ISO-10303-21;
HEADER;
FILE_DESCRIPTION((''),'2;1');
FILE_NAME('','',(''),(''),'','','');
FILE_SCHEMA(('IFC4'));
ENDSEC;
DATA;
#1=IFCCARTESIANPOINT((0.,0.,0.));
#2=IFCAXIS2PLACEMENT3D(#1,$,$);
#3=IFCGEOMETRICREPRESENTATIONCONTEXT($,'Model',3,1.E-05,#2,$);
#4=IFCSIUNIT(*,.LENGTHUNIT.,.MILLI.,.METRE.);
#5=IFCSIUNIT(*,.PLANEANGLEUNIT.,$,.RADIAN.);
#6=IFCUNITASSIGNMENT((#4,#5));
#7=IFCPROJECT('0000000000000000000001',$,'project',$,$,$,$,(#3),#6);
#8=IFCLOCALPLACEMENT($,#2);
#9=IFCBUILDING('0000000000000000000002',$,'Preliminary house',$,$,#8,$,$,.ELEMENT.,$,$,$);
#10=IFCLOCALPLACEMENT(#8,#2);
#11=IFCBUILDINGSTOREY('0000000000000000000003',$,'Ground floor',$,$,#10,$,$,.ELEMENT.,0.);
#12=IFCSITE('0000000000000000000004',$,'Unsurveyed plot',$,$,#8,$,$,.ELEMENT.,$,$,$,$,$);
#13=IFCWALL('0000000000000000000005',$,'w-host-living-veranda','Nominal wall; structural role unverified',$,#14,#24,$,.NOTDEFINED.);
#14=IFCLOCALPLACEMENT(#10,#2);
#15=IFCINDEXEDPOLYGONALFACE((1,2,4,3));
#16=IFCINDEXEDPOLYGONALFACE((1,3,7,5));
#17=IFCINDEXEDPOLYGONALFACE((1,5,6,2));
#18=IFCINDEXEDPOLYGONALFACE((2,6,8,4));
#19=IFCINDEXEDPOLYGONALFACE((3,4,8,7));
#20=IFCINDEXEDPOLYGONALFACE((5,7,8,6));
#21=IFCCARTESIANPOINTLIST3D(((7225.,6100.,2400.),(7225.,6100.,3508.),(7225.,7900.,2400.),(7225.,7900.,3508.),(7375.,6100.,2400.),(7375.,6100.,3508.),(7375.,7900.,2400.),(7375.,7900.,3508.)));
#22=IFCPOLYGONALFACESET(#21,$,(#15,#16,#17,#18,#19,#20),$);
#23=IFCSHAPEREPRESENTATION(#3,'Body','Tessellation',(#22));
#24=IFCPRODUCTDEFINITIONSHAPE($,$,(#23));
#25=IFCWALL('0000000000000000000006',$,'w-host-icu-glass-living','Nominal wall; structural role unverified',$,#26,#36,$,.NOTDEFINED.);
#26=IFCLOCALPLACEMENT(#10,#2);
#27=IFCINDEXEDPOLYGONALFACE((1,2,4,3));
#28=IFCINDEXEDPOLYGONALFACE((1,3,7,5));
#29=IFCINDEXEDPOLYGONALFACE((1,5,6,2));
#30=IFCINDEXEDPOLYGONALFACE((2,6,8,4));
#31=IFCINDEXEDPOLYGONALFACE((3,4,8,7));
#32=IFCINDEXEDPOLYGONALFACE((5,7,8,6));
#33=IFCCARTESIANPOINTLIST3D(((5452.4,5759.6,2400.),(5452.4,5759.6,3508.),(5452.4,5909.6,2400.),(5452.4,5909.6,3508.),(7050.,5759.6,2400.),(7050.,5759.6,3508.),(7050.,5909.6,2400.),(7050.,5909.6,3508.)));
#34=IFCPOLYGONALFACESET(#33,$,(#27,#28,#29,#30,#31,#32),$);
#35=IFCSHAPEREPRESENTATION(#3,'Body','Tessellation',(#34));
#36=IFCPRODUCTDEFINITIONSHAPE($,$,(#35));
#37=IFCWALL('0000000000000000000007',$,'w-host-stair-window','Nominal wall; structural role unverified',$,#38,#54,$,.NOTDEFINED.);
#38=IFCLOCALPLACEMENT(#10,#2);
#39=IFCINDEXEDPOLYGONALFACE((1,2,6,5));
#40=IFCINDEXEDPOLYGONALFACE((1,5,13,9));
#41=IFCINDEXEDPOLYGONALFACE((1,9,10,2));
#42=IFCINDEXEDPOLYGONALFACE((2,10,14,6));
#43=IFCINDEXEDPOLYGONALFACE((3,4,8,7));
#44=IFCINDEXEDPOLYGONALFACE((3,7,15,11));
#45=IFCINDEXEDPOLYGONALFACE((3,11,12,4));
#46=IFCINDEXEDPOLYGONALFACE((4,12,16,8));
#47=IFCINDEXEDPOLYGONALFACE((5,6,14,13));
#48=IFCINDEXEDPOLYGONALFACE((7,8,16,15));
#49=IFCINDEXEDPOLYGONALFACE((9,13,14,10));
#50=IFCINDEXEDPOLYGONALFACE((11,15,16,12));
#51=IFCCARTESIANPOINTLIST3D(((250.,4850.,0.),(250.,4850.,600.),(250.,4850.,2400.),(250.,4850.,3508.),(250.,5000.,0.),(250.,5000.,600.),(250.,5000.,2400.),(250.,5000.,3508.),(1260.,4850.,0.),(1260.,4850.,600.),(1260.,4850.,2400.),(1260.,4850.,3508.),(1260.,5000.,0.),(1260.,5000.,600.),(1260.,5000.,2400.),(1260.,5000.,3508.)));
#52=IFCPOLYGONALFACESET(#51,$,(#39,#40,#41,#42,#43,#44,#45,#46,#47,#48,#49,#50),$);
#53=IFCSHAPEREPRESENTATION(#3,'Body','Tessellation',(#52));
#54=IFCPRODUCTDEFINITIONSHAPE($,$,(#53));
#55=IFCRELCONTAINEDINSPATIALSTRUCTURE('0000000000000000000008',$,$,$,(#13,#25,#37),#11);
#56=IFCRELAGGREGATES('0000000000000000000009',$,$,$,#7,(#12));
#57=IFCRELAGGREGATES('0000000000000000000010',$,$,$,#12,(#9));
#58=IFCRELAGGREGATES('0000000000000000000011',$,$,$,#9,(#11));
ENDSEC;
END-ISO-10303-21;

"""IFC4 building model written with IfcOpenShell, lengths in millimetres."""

from ifc_helpers import new_model, si_unit, frame, origin, place, context, project, spatial, polyline, outline, extrude, element, save


model = new_model("IFC4")

# Units and contexts
model_context = context("Model", 3, precision=1e-05, world=origin())
ifc_project = project(units=[si_unit("LENGTHUNIT", "METRE", prefix="MILLI"), si_unit("PLANEANGLEUNIT", "RADIAN")], contexts=[model_context])

# Site, building, storey
placement_1 = place(None, origin())
site = spatial("IfcSite", under=ifc_project, at=placement_1, Name="Unsurveyed plot", CompositionType="ELEMENT")
building = spatial("IfcBuilding", under=site, at=placement_1, Name="Preliminary house", CompositionType="ELEMENT")
placement_2 = place(placement_1, origin())
storey = spatial("IfcBuildingStorey", under=building, at=placement_2, Name="Ground floor", CompositionType="ELEMENT", Elevation=0.0)

# Walls, openings
wall_1 = element("IfcWall", 1, at=placement_2, inside=storey, Name="w-host-living-veranda", Description="Nominal wall; structural role unverified", PredefinedType="NOTDEFINED", context=model_context, shape_type="SweptSolid", body=[
    extrude(outline(polyline([(7375.0, 6100.0), (7375.0, 7900.0), (7225.0, 7900.0), (7225.0, 6100.0), (7375.0, 6100.0)])), origin(), (0.0, 0.0, 1.0), 3508.0),
])
element("IfcOpeningElement", 2, at=placement_2, cuts=wall_1, PredefinedType="OPENING", context=model_context, shape_type="SweptSolid", body=[
    extrude(outline(polyline([(7750.0, 6100.0), (7750.0, 7900.0), (6850.0, 7900.0), (6850.0, 6100.0), (7750.0, 6100.0)])), origin(), (0.0, 0.0, 1.0), 2400.0),
])
wall_2 = element("IfcWall", 3, at=placement_2, inside=storey, Name="w-host-icu-glass-living", Description="Nominal wall; structural role unverified", PredefinedType="NOTDEFINED", context=model_context, shape_type="SweptSolid", body=[
    extrude(outline(polyline([(5452.4, 5759.6), (7050.0, 5759.6), (7050.0, 5909.6), (5452.4, 5909.6), (5452.4, 5759.6)])), origin(), (0.0, 0.0, 1.0), 3508.0),
])
element("IfcOpeningElement", 4, at=placement_2, cuts=wall_2, PredefinedType="OPENING", context=model_context, shape_type="SweptSolid", body=[
    extrude(outline(polyline([(5452.4, 5384.6), (7050.0, 5384.6), (7050.0, 6284.6), (5452.4, 6284.6), (5452.4, 5384.6)])), origin(), (0.0, 0.0, 1.0), 2400.0),
])
wall_3 = element("IfcWall", 5, at=placement_2, inside=storey, Name="w-host-stair-window", Description="Nominal wall; structural role unverified", PredefinedType="NOTDEFINED", context=model_context, shape_type="SweptSolid", body=[
    extrude(outline(polyline([(250.0, 4850.0), (1260.0, 4850.0), (1260.0, 5000.0), (250.0, 5000.0), (250.0, 4850.0)])), origin(), (0.0, 0.0, 1.0), 3508.0),
])
element("IfcOpeningElement", 6, at=placement_2, cuts=wall_3, PredefinedType="OPENING", context=model_context, shape_type="SweptSolid", body=[
    extrude(outline(polyline([(250.0, 4475.0), (1260.0, 4475.0), (1260.0, 5375.0), (250.0, 5375.0), (250.0, 4475.0)])), frame((0.0, 0.0, 600.0)), (0.0, 0.0, 1.0), 1800.0),
])

save(model, "model.ifc")
